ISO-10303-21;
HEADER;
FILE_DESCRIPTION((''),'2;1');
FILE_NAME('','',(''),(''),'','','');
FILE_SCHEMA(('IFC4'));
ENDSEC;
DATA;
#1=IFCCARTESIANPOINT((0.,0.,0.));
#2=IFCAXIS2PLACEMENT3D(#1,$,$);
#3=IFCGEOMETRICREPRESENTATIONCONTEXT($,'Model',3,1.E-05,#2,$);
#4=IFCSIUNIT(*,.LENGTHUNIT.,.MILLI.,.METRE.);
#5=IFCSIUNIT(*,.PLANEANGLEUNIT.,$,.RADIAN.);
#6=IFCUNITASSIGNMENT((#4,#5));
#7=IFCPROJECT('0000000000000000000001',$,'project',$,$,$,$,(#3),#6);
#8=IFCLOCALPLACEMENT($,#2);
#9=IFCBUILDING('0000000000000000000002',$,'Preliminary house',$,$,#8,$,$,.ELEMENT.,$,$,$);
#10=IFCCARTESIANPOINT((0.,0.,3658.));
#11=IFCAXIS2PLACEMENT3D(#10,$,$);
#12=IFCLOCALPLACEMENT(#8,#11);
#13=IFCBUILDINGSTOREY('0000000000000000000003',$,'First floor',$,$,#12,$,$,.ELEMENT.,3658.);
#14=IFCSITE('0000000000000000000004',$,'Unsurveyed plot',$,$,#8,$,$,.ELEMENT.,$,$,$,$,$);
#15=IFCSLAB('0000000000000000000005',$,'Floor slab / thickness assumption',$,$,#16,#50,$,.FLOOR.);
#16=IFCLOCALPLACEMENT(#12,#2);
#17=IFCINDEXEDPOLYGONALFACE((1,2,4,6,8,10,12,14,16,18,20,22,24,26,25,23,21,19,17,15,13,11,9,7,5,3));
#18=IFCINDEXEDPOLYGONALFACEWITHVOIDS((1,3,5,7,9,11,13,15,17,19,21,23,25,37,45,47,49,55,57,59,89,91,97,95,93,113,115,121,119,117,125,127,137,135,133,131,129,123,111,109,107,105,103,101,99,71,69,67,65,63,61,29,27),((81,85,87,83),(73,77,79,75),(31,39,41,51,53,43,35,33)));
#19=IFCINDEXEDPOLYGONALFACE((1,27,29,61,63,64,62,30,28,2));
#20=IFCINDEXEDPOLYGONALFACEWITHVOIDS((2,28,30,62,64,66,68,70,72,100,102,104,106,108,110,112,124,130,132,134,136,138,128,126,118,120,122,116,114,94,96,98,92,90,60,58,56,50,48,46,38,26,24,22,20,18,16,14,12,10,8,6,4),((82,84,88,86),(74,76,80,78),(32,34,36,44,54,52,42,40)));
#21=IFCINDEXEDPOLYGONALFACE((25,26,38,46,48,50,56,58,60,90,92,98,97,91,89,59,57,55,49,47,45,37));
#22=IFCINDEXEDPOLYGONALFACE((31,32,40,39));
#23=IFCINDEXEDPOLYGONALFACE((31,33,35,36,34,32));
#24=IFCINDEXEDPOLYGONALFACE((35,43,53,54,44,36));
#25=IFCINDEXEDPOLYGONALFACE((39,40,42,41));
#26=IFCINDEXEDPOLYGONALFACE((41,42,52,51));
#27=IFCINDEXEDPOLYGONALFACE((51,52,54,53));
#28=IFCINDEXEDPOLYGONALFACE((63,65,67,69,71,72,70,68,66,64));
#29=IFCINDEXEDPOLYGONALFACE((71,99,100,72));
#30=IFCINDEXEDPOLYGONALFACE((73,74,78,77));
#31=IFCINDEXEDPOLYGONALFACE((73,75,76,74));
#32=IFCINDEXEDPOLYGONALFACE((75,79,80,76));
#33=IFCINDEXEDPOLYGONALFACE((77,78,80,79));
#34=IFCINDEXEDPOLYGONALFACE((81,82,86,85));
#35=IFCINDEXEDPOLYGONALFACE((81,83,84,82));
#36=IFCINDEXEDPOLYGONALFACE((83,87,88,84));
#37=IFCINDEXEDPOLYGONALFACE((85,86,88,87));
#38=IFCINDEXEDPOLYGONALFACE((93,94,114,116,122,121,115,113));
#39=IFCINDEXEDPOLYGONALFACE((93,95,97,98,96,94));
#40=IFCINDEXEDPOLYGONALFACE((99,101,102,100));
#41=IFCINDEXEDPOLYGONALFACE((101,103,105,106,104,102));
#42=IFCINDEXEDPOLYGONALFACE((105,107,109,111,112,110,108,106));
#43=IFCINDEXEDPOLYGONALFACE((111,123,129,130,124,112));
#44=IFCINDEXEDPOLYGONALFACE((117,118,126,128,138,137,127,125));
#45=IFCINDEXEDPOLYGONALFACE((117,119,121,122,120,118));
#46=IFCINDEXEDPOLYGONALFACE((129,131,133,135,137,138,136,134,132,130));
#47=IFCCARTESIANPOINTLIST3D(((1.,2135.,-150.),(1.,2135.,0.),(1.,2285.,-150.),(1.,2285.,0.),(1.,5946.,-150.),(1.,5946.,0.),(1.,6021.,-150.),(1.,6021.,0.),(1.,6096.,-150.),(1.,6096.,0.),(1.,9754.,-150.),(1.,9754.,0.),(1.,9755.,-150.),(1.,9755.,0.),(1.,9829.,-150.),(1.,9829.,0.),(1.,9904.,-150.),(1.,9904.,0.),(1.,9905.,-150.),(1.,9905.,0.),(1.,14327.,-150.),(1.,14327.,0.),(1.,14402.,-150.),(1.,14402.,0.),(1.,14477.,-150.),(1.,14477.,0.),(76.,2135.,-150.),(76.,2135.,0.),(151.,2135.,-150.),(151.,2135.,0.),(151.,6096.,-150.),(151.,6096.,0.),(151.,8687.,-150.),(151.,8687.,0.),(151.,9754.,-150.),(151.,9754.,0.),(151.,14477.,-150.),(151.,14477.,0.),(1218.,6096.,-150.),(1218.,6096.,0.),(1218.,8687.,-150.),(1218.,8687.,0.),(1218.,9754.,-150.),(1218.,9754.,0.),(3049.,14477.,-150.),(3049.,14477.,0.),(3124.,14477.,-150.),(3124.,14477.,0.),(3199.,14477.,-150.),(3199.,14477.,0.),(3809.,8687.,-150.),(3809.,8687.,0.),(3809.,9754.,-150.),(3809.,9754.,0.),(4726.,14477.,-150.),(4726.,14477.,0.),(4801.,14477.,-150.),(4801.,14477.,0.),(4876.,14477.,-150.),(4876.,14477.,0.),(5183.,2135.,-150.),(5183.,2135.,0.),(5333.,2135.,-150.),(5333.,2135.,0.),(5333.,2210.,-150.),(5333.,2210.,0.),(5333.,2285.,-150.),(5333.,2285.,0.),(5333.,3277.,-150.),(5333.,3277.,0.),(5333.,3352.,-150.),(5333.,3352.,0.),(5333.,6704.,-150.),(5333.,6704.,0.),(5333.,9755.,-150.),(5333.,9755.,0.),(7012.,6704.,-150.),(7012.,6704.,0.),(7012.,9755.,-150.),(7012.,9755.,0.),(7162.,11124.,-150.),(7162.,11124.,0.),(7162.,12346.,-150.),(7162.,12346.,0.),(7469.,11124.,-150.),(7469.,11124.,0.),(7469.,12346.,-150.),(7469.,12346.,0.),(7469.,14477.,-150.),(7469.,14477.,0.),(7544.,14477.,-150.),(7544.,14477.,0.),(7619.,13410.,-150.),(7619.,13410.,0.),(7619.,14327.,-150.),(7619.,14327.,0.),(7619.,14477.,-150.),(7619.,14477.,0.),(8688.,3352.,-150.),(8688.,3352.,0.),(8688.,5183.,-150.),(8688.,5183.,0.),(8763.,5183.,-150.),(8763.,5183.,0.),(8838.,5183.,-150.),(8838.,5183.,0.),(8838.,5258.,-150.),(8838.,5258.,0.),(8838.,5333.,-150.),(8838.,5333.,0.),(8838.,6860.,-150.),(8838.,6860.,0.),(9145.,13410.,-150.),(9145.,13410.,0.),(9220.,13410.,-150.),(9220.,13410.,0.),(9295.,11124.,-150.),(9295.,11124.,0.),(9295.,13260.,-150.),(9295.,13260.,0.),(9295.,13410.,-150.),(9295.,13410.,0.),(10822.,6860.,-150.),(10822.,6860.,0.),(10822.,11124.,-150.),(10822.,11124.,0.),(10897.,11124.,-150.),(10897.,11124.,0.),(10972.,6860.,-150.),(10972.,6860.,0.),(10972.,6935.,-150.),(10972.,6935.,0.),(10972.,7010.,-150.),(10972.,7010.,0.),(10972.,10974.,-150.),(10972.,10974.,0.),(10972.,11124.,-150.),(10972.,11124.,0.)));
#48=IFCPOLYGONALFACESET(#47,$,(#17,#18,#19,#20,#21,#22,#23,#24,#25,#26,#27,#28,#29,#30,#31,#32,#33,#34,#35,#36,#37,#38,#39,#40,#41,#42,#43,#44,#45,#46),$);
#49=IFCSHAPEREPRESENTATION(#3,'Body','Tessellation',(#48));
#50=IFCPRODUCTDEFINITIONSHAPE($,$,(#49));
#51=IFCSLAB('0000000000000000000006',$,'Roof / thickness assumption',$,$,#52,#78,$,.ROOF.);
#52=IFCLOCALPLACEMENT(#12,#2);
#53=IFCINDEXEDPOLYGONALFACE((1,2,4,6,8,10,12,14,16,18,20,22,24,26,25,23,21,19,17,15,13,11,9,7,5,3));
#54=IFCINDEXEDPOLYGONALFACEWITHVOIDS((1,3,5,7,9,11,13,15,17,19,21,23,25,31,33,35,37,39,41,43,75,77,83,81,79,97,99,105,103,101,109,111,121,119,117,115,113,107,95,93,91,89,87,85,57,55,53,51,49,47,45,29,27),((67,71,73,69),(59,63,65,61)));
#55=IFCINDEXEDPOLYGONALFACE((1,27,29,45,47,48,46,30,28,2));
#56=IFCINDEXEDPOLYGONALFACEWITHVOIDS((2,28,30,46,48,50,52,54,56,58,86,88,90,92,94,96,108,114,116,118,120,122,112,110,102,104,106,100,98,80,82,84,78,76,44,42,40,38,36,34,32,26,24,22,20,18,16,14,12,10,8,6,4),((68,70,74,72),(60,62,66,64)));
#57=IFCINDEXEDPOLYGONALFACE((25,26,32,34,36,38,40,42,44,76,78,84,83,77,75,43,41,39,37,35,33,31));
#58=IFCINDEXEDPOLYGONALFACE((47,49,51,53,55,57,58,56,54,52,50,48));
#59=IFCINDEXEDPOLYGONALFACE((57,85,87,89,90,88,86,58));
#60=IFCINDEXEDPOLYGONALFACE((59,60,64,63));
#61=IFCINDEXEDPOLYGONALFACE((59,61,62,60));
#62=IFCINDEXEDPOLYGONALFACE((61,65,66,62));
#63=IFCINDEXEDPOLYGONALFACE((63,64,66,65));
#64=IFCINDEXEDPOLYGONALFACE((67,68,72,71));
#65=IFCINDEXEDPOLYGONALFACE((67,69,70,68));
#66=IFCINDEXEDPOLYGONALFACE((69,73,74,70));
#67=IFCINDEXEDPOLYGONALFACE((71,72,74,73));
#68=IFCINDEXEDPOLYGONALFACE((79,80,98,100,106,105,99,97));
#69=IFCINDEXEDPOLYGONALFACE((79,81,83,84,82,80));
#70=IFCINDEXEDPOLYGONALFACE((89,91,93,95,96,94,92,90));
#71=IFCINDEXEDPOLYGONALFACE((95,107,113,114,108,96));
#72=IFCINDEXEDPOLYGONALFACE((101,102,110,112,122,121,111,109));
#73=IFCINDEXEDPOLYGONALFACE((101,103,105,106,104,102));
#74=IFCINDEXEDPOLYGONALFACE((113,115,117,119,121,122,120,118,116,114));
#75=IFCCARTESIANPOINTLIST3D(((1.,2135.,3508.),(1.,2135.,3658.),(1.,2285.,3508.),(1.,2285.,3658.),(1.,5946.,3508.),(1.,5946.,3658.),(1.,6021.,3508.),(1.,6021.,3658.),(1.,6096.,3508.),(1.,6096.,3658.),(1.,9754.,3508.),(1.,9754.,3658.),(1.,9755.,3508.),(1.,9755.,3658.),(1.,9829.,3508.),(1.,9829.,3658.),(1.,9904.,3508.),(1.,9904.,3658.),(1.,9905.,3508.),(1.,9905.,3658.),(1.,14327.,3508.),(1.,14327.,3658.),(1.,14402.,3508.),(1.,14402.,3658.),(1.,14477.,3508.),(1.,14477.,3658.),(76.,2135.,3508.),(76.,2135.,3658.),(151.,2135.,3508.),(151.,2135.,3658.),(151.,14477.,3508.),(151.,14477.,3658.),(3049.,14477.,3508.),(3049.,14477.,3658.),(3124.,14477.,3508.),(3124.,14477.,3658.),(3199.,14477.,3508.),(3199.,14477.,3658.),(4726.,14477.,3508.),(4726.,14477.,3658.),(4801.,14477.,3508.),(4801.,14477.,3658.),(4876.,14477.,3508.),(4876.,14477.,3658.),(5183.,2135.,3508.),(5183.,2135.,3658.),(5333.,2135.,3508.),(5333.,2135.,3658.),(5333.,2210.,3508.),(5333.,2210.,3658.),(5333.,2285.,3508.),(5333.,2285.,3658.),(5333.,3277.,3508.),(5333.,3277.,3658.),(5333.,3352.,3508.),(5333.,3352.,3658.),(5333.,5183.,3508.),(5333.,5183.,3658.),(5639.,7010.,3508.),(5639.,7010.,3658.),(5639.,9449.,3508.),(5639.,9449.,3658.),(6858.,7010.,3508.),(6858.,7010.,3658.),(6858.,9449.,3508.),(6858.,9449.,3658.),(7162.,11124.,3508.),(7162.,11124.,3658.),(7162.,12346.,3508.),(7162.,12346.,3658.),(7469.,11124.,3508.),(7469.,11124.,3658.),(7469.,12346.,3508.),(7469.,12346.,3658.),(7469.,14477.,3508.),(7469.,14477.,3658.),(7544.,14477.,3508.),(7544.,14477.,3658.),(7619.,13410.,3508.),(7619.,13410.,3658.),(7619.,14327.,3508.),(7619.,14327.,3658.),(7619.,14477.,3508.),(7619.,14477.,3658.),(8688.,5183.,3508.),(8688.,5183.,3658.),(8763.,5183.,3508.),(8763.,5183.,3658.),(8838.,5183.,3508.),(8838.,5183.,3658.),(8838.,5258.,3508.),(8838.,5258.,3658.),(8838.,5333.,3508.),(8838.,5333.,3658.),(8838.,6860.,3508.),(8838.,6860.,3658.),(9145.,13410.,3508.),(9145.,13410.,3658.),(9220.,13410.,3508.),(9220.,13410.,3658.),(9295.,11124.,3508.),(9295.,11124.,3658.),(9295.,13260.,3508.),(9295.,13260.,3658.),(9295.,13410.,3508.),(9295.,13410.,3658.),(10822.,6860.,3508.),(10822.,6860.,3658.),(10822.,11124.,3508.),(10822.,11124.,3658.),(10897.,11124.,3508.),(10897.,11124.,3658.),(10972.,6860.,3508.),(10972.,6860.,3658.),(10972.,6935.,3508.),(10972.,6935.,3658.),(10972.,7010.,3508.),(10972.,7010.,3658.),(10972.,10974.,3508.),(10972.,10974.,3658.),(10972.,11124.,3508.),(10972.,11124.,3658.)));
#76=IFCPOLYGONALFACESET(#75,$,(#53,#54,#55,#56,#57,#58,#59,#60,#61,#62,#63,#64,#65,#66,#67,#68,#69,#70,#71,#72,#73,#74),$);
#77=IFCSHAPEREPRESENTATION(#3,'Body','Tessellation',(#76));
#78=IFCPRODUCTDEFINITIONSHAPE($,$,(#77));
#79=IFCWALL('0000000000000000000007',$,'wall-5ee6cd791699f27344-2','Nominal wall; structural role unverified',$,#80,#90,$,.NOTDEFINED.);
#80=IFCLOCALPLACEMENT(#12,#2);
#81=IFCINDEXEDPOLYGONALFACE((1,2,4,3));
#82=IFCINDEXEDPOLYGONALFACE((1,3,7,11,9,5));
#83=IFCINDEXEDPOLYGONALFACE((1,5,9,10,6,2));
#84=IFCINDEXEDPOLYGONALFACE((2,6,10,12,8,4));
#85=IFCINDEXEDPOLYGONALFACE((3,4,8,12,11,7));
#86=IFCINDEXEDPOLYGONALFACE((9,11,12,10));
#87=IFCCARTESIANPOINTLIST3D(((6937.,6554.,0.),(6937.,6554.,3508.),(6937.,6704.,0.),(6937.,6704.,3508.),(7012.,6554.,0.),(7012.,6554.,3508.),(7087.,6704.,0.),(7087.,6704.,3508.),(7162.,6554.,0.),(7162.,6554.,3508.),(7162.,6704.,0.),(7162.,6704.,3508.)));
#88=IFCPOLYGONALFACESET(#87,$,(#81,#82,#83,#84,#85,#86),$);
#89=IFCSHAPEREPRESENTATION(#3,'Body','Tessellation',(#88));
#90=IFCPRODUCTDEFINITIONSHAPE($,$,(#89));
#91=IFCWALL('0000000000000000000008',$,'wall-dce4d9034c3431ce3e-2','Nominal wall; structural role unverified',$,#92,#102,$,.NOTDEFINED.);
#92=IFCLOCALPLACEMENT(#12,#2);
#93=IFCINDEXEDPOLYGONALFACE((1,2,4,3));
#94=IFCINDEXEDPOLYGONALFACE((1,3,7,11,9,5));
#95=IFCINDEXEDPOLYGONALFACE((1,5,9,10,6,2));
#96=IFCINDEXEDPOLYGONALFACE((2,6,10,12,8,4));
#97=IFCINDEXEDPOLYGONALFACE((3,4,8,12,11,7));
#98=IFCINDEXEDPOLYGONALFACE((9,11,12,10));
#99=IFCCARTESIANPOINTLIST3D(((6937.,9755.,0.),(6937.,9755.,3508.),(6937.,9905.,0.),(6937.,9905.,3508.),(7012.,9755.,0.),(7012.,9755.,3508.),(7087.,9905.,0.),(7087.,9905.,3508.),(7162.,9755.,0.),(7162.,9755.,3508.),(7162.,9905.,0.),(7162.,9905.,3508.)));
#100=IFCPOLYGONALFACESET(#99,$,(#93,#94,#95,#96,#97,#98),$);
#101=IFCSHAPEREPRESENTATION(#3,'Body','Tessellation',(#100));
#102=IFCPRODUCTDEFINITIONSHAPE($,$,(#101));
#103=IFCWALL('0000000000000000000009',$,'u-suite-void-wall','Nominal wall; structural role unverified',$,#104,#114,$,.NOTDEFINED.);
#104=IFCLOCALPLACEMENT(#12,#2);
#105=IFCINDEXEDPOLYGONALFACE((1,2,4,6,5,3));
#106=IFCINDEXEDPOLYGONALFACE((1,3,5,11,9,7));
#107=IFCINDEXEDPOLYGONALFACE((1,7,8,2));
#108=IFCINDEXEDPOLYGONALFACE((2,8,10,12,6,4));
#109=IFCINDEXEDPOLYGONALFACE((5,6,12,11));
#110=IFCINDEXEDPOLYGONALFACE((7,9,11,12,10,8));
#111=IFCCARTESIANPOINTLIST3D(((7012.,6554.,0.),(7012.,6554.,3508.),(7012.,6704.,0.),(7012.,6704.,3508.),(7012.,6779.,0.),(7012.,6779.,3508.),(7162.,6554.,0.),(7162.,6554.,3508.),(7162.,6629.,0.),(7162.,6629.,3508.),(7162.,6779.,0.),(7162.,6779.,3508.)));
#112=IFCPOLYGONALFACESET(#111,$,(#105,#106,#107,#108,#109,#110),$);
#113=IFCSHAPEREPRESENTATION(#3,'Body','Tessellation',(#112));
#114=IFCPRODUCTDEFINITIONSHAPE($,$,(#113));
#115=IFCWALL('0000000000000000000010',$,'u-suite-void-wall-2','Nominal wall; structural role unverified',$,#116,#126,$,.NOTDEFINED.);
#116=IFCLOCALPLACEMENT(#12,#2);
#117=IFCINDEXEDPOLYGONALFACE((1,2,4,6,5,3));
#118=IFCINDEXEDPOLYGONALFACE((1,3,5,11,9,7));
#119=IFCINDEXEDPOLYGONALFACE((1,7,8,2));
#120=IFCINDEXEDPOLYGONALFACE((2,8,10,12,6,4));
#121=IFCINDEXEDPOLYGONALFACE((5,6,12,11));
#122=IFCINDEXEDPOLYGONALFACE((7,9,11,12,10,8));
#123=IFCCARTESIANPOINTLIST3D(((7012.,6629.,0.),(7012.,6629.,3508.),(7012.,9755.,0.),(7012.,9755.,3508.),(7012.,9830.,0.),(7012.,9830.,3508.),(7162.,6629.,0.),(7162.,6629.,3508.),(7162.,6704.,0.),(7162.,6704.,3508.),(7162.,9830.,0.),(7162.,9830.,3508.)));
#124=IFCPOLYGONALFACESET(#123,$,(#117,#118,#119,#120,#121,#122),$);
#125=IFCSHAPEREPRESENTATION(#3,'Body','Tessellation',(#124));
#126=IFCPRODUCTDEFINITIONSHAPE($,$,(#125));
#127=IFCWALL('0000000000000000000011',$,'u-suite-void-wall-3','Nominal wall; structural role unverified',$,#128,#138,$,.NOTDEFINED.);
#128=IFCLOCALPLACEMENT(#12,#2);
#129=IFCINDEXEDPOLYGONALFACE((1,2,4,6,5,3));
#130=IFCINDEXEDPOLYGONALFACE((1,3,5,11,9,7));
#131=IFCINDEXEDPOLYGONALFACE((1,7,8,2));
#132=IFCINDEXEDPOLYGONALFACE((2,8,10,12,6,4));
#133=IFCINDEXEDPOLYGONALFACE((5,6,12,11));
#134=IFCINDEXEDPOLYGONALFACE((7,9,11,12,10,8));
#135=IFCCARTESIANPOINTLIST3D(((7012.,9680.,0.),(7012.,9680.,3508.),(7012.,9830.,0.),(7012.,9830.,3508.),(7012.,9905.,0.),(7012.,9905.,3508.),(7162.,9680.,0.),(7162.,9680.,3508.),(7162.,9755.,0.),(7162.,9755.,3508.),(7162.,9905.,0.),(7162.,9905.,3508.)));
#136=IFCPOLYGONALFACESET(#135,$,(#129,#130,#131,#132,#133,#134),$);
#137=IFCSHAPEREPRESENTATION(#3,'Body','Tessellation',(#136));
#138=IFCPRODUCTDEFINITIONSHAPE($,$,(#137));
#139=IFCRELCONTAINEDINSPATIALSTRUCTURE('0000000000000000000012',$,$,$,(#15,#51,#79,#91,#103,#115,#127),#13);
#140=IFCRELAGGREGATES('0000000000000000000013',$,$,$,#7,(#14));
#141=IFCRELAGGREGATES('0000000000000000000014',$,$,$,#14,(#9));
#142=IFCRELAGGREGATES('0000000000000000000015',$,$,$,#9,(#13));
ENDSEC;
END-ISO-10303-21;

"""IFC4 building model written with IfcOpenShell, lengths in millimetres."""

from ifc_helpers import new_model, si_unit, frame, origin, place, context, project, spatial, polyline, outline, extrude, element, save


model = new_model("IFC4")

# Units and contexts
model_context = context("Model", 3, precision=1e-05, world=origin())
ifc_project = project(units=[si_unit("LENGTHUNIT", "METRE", prefix="MILLI"), si_unit("PLANEANGLEUNIT", "RADIAN")], contexts=[model_context])

# Site, building, storey
placement_1 = place(None, origin())
site = spatial("IfcSite", under=ifc_project, at=placement_1, Name="Unsurveyed plot", CompositionType="ELEMENT")
building = spatial("IfcBuilding", under=site, at=placement_1, Name="Preliminary house", CompositionType="ELEMENT")
placement_2 = place(placement_1, frame((0.0, 0.0, 3658.0)))
storey = spatial("IfcBuildingStorey", under=building, at=placement_2, Name="First floor", CompositionType="ELEMENT", Elevation=3658.0)

# Slabs
element("IfcSlab", 1, at=placement_2, inside=storey, Name="Floor slab / thickness assumption", PredefinedType="FLOOR", context=model_context, shape_type="SweptSolid", body=[
    extrude(outline(polyline([(1.0, 5946.0), (1.0, 6021.0), (1.0, 6096.0), (1.0, 9754.0), (1.0, 9755.0), (1.0, 9829.0), (1.0, 9904.0), (1.0, 9905.0), (1.0, 14327.0), (1.0, 14402.0), (1.0, 14477.0), (151.0, 14477.0), (3049.0, 14477.0), (3124.0, 14477.0), (3199.0, 14477.0), (4726.0, 14477.0), (4801.0, 14477.0), (4876.0, 14477.0), (7469.0, 14477.0), (7544.0, 14477.0), (7619.0, 14477.0), (7619.0, 14327.0), (7619.0, 13410.0), (9145.0, 13410.0), (9220.0, 13410.0), (9295.0, 13410.0), (9295.0, 13260.0), (9295.0, 11124.0), (10822.0, 11124.0), (10897.0, 11124.0), (10972.0, 11124.0), (10972.0, 10974.0), (10972.0, 7010.0), (10972.0, 6935.0), (10972.0, 6860.0), (10822.0, 6860.0), (8838.0, 6860.0), (8838.0, 5333.0), (8838.0, 5258.0), (8838.0, 5183.0), (8763.0, 5183.0), (8688.0, 5183.0), (8688.0, 3352.0), (5333.0, 3352.0), (5333.0, 3277.0), (5333.0, 2285.0), (5333.0, 2210.0), (5333.0, 2135.0), (5183.0, 2135.0), (151.0, 2135.0), (76.0, 2135.0), (1.0, 2135.0), (1.0, 2285.0), (1.0, 5946.0)]), holes=[polyline([(7469.0, 11124.0), (7469.0, 12346.0), (7162.0, 12346.0), (7162.0, 11124.0), (7469.0, 11124.0)]), polyline([(5333.0, 9755.0), (5333.0, 6704.0), (7012.0, 6704.0), (7012.0, 9755.0), (5333.0, 9755.0)]), polyline([(1218.0, 8687.0), (3809.0, 8687.0), (3809.0, 9754.0), (1218.0, 9754.0), (151.0, 9754.0), (151.0, 8687.0), (151.0, 6096.0), (1218.0, 6096.0), (1218.0, 8687.0)])]), frame((0.0, 0.0, -150.0)), (0.0, 0.0, 1.0), 150.0),
])
element("IfcSlab", 2, at=placement_2, inside=storey, Name="Roof / thickness assumption", PredefinedType="ROOF", context=model_context, shape_type="SweptSolid", body=[
    extrude(outline(polyline([(1.0, 5946.0), (1.0, 6021.0), (1.0, 6096.0), (1.0, 9754.0), (1.0, 9755.0), (1.0, 9829.0), (1.0, 9904.0), (1.0, 9905.0), (1.0, 14327.0), (1.0, 14402.0), (1.0, 14477.0), (151.0, 14477.0), (3049.0, 14477.0), (3124.0, 14477.0), (3199.0, 14477.0), (4726.0, 14477.0), (4801.0, 14477.0), (4876.0, 14477.0), (7469.0, 14477.0), (7544.0, 14477.0), (7619.0, 14477.0), (7619.0, 14327.0), (7619.0, 13410.0), (9145.0, 13410.0), (9220.0, 13410.0), (9295.0, 13410.0), (9295.0, 13260.0), (9295.0, 11124.0), (10822.0, 11124.0), (10897.0, 11124.0), (10972.0, 11124.0), (10972.0, 10974.0), (10972.0, 7010.0), (10972.0, 6935.0), (10972.0, 6860.0), (10822.0, 6860.0), (8838.0, 6860.0), (8838.0, 5333.0), (8838.0, 5258.0), (8838.0, 5183.0), (8763.0, 5183.0), (8688.0, 5183.0), (5333.0, 5183.0), (5333.0, 3352.0), (5333.0, 3277.0), (5333.0, 2285.0), (5333.0, 2210.0), (5333.0, 2135.0), (5183.0, 2135.0), (151.0, 2135.0), (76.0, 2135.0), (1.0, 2135.0), (1.0, 2285.0), (1.0, 5946.0)]), holes=[polyline([(7469.0, 11124.0), (7469.0, 12346.0), (7162.0, 12346.0), (7162.0, 11124.0), (7469.0, 11124.0)]), polyline([(6858.0, 7010.0), (6858.0, 9449.0), (5639.0, 9449.0), (5639.0, 7010.0), (6858.0, 7010.0)])]), frame((0.0, 0.0, 3508.0)), (0.0, 0.0, 1.0), 150.0),
])

# Walls
element("IfcWall", 3, at=placement_2, inside=storey, Name="wall-5ee6cd791699f27344-2", Description="Nominal wall; structural role unverified", PredefinedType="NOTDEFINED", context=model_context, shape_type="SweptSolid", body=[
    extrude(outline(polyline([(7087.0, 6704.0), (7162.0, 6704.0), (7162.0, 6554.0), (7012.0, 6554.0), (6937.0, 6554.0), (6937.0, 6704.0), (7087.0, 6704.0)])), origin(), (0.0, 0.0, 1.0), 3508.0),
])
element("IfcWall", 4, at=placement_2, inside=storey, Name="wall-dce4d9034c3431ce3e-2", Description="Nominal wall; structural role unverified", PredefinedType="NOTDEFINED", context=model_context, shape_type="SweptSolid", body=[
    extrude(outline(polyline([(7087.0, 9905.0), (7162.0, 9905.0), (7162.0, 9755.0), (7012.0, 9755.0), (6937.0, 9755.0), (6937.0, 9905.0), (7087.0, 9905.0)])), origin(), (0.0, 0.0, 1.0), 3508.0),
])
element("IfcWall", 5, at=placement_2, inside=storey, Name="u-suite-void-wall", Description="Nominal wall; structural role unverified", PredefinedType="NOTDEFINED", context=model_context, shape_type="SweptSolid", body=[
    extrude(outline(polyline([(7012.0, 6704.0), (7012.0, 6779.0), (7162.0, 6779.0), (7162.0, 6629.0), (7162.0, 6554.0), (7012.0, 6554.0), (7012.0, 6704.0)])), origin(), (0.0, 0.0, 1.0), 3508.0),
])
element("IfcWall", 6, at=placement_2, inside=storey, Name="u-suite-void-wall-2", Description="Nominal wall; structural role unverified", PredefinedType="NOTDEFINED", context=model_context, shape_type="SweptSolid", body=[
    extrude(outline(polyline([(7012.0, 9755.0), (7012.0, 9830.0), (7162.0, 9830.0), (7162.0, 6704.0), (7162.0, 6629.0), (7012.0, 6629.0), (7012.0, 9755.0)])), origin(), (0.0, 0.0, 1.0), 3508.0),
])
element("IfcWall", 7, at=placement_2, inside=storey, Name="u-suite-void-wall-3", Description="Nominal wall; structural role unverified", PredefinedType="NOTDEFINED", context=model_context, shape_type="SweptSolid", body=[
    extrude(outline(polyline([(7012.0, 9830.0), (7012.0, 9905.0), (7162.0, 9905.0), (7162.0, 9755.0), (7162.0, 9680.0), (7012.0, 9680.0), (7012.0, 9830.0)])), origin(), (0.0, 0.0, 1.0), 3508.0),
])

save(model, "model.ifc")
